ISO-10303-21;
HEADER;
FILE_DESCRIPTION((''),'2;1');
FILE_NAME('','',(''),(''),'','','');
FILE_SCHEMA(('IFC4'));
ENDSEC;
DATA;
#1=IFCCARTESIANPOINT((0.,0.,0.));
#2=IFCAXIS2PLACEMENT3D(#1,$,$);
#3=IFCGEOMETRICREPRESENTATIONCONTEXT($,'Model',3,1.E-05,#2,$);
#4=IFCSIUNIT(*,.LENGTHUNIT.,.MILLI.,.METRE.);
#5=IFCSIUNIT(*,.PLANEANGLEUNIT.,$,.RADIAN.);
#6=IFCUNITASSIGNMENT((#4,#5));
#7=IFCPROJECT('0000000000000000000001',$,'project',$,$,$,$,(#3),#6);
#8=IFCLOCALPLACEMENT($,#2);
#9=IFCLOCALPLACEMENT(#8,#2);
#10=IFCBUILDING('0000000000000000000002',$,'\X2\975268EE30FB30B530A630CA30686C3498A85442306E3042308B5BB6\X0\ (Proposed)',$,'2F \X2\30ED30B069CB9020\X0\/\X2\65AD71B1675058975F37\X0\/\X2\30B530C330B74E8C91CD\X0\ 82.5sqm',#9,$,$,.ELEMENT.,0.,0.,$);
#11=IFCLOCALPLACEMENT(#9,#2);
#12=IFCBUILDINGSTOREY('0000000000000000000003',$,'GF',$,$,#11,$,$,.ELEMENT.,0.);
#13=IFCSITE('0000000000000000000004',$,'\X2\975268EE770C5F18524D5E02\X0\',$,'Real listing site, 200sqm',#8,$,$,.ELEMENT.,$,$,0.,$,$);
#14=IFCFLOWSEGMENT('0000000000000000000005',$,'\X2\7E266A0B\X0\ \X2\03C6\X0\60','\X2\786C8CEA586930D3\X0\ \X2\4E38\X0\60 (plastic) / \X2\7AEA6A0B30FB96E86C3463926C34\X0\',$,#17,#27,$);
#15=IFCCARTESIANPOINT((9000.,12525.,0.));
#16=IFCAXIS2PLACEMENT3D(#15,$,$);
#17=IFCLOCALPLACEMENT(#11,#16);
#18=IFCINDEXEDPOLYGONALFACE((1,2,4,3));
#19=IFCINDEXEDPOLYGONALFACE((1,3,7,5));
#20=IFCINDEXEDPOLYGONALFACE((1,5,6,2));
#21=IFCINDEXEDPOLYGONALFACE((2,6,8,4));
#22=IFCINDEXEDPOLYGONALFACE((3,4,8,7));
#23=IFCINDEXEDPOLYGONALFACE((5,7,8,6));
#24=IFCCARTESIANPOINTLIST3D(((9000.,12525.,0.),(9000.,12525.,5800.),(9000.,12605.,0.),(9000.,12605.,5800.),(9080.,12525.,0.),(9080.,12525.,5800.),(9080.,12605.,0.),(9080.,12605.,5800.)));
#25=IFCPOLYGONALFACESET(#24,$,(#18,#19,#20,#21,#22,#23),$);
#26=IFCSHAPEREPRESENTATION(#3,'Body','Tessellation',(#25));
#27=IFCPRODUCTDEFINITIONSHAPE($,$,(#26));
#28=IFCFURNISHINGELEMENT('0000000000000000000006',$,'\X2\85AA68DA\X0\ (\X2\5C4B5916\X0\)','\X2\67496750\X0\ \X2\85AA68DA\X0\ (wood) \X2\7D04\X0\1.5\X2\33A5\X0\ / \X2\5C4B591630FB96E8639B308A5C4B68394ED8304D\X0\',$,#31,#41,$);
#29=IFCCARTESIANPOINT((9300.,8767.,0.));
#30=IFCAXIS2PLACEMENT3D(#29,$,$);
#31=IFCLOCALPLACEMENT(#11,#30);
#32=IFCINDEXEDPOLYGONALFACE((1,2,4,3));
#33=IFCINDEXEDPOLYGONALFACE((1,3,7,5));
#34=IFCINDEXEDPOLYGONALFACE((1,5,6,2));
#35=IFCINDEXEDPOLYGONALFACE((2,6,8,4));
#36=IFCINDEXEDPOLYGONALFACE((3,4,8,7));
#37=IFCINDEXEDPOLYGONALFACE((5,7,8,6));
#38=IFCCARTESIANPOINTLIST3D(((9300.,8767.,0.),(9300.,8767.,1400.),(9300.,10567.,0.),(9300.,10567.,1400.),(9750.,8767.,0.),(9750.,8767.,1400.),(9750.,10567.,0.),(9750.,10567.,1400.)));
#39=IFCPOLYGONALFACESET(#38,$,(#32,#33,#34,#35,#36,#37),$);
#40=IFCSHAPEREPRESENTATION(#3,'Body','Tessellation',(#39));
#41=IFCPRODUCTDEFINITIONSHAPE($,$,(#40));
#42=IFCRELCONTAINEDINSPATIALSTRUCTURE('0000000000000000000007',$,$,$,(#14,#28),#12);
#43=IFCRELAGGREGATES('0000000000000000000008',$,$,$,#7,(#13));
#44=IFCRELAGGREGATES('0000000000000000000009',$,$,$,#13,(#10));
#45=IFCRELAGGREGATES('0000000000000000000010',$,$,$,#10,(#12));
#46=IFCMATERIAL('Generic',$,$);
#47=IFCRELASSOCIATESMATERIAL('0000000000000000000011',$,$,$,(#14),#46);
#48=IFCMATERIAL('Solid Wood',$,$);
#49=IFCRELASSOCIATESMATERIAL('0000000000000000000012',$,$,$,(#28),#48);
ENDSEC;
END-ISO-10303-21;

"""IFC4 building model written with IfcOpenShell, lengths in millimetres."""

from ifc_helpers import new_model, si_unit, frame, frame_2d, origin, place, context, project, spatial, rectangle, extrude, material, element, save


model = new_model("IFC4")

# Units and contexts
model_context = context("Model", 3, precision=1e-05, world=origin())
ifc_project = project(units=[si_unit("LENGTHUNIT", "METRE", prefix="MILLI"), si_unit("PLANEANGLEUNIT", "RADIAN")], contexts=[model_context])

# Site, building, storey
site_placement = place(None, origin())
site = spatial("IfcSite", under=ifc_project, at=site_placement, Name="青森県弘前市", ObjectType="Real listing site, 200sqm", CompositionType="ELEMENT", RefElevation=0.0)
building_placement = place(site_placement, origin())
building = spatial("IfcBuilding", under=site, at=building_placement, Name="青森・サウナと水風呂のある家 (Proposed)", ObjectType="2F ログ構造/断熱材増強/サッシ二重 82.5sqm", CompositionType="ELEMENT", ElevationOfRefHeight=0.0, ElevationOfTerrain=0.0)
storey_placement = place(building_placement, origin())
storey = spatial("IfcBuildingStorey", under=building, at=storey_placement, Name="GF", CompositionType="ELEMENT", Elevation=0.0)

# Shared definitions
ifc_material_1 = material(Name="Solid Wood")

# Flow segment
ifc_material_2 = material(Name="Generic")
flow_segment_placement = place(storey_placement, frame((9000.0, 12525.0, 0.0)))
element("IfcFlowSegment", 1, at=flow_segment_placement, inside=storey, material=ifc_material_2, Name="縦樋 φ60", Description="硬質塩ビ 丸60 (plastic) / 竪樋・雨水排水", context=model_context, shape_type="SweptSolid", body=[
    extrude(rectangle(XDim=80.0, YDim=80.0, at=frame_2d((40.0, 40.0))), frame((9000.0, 12525.0, 0.0)), (0.0, 0.0, 1.0), 5800.0),
])

# Furnishing element
furnishing_placement = place(storey_placement, frame((9300.0, 8767.0, 0.0)))
element("IfcFurnishingElement", 2, at=furnishing_placement, inside=storey, material=ifc_material_1, Name="薪棚 (屋外)", Description="杉材 薪棚 (wood) 約1.5㎥ / 屋外・雨掛り屋根付き", context=model_context, shape_type="SweptSolid", body=[
    extrude(rectangle(XDim=450.0, YDim=1800.0, at=frame_2d((225.0, 900.0))), frame((9300.0, 8767.0, 0.0)), (0.0, 0.0, 1.0), 1400.0),
])

save(model, "model.ifc")
